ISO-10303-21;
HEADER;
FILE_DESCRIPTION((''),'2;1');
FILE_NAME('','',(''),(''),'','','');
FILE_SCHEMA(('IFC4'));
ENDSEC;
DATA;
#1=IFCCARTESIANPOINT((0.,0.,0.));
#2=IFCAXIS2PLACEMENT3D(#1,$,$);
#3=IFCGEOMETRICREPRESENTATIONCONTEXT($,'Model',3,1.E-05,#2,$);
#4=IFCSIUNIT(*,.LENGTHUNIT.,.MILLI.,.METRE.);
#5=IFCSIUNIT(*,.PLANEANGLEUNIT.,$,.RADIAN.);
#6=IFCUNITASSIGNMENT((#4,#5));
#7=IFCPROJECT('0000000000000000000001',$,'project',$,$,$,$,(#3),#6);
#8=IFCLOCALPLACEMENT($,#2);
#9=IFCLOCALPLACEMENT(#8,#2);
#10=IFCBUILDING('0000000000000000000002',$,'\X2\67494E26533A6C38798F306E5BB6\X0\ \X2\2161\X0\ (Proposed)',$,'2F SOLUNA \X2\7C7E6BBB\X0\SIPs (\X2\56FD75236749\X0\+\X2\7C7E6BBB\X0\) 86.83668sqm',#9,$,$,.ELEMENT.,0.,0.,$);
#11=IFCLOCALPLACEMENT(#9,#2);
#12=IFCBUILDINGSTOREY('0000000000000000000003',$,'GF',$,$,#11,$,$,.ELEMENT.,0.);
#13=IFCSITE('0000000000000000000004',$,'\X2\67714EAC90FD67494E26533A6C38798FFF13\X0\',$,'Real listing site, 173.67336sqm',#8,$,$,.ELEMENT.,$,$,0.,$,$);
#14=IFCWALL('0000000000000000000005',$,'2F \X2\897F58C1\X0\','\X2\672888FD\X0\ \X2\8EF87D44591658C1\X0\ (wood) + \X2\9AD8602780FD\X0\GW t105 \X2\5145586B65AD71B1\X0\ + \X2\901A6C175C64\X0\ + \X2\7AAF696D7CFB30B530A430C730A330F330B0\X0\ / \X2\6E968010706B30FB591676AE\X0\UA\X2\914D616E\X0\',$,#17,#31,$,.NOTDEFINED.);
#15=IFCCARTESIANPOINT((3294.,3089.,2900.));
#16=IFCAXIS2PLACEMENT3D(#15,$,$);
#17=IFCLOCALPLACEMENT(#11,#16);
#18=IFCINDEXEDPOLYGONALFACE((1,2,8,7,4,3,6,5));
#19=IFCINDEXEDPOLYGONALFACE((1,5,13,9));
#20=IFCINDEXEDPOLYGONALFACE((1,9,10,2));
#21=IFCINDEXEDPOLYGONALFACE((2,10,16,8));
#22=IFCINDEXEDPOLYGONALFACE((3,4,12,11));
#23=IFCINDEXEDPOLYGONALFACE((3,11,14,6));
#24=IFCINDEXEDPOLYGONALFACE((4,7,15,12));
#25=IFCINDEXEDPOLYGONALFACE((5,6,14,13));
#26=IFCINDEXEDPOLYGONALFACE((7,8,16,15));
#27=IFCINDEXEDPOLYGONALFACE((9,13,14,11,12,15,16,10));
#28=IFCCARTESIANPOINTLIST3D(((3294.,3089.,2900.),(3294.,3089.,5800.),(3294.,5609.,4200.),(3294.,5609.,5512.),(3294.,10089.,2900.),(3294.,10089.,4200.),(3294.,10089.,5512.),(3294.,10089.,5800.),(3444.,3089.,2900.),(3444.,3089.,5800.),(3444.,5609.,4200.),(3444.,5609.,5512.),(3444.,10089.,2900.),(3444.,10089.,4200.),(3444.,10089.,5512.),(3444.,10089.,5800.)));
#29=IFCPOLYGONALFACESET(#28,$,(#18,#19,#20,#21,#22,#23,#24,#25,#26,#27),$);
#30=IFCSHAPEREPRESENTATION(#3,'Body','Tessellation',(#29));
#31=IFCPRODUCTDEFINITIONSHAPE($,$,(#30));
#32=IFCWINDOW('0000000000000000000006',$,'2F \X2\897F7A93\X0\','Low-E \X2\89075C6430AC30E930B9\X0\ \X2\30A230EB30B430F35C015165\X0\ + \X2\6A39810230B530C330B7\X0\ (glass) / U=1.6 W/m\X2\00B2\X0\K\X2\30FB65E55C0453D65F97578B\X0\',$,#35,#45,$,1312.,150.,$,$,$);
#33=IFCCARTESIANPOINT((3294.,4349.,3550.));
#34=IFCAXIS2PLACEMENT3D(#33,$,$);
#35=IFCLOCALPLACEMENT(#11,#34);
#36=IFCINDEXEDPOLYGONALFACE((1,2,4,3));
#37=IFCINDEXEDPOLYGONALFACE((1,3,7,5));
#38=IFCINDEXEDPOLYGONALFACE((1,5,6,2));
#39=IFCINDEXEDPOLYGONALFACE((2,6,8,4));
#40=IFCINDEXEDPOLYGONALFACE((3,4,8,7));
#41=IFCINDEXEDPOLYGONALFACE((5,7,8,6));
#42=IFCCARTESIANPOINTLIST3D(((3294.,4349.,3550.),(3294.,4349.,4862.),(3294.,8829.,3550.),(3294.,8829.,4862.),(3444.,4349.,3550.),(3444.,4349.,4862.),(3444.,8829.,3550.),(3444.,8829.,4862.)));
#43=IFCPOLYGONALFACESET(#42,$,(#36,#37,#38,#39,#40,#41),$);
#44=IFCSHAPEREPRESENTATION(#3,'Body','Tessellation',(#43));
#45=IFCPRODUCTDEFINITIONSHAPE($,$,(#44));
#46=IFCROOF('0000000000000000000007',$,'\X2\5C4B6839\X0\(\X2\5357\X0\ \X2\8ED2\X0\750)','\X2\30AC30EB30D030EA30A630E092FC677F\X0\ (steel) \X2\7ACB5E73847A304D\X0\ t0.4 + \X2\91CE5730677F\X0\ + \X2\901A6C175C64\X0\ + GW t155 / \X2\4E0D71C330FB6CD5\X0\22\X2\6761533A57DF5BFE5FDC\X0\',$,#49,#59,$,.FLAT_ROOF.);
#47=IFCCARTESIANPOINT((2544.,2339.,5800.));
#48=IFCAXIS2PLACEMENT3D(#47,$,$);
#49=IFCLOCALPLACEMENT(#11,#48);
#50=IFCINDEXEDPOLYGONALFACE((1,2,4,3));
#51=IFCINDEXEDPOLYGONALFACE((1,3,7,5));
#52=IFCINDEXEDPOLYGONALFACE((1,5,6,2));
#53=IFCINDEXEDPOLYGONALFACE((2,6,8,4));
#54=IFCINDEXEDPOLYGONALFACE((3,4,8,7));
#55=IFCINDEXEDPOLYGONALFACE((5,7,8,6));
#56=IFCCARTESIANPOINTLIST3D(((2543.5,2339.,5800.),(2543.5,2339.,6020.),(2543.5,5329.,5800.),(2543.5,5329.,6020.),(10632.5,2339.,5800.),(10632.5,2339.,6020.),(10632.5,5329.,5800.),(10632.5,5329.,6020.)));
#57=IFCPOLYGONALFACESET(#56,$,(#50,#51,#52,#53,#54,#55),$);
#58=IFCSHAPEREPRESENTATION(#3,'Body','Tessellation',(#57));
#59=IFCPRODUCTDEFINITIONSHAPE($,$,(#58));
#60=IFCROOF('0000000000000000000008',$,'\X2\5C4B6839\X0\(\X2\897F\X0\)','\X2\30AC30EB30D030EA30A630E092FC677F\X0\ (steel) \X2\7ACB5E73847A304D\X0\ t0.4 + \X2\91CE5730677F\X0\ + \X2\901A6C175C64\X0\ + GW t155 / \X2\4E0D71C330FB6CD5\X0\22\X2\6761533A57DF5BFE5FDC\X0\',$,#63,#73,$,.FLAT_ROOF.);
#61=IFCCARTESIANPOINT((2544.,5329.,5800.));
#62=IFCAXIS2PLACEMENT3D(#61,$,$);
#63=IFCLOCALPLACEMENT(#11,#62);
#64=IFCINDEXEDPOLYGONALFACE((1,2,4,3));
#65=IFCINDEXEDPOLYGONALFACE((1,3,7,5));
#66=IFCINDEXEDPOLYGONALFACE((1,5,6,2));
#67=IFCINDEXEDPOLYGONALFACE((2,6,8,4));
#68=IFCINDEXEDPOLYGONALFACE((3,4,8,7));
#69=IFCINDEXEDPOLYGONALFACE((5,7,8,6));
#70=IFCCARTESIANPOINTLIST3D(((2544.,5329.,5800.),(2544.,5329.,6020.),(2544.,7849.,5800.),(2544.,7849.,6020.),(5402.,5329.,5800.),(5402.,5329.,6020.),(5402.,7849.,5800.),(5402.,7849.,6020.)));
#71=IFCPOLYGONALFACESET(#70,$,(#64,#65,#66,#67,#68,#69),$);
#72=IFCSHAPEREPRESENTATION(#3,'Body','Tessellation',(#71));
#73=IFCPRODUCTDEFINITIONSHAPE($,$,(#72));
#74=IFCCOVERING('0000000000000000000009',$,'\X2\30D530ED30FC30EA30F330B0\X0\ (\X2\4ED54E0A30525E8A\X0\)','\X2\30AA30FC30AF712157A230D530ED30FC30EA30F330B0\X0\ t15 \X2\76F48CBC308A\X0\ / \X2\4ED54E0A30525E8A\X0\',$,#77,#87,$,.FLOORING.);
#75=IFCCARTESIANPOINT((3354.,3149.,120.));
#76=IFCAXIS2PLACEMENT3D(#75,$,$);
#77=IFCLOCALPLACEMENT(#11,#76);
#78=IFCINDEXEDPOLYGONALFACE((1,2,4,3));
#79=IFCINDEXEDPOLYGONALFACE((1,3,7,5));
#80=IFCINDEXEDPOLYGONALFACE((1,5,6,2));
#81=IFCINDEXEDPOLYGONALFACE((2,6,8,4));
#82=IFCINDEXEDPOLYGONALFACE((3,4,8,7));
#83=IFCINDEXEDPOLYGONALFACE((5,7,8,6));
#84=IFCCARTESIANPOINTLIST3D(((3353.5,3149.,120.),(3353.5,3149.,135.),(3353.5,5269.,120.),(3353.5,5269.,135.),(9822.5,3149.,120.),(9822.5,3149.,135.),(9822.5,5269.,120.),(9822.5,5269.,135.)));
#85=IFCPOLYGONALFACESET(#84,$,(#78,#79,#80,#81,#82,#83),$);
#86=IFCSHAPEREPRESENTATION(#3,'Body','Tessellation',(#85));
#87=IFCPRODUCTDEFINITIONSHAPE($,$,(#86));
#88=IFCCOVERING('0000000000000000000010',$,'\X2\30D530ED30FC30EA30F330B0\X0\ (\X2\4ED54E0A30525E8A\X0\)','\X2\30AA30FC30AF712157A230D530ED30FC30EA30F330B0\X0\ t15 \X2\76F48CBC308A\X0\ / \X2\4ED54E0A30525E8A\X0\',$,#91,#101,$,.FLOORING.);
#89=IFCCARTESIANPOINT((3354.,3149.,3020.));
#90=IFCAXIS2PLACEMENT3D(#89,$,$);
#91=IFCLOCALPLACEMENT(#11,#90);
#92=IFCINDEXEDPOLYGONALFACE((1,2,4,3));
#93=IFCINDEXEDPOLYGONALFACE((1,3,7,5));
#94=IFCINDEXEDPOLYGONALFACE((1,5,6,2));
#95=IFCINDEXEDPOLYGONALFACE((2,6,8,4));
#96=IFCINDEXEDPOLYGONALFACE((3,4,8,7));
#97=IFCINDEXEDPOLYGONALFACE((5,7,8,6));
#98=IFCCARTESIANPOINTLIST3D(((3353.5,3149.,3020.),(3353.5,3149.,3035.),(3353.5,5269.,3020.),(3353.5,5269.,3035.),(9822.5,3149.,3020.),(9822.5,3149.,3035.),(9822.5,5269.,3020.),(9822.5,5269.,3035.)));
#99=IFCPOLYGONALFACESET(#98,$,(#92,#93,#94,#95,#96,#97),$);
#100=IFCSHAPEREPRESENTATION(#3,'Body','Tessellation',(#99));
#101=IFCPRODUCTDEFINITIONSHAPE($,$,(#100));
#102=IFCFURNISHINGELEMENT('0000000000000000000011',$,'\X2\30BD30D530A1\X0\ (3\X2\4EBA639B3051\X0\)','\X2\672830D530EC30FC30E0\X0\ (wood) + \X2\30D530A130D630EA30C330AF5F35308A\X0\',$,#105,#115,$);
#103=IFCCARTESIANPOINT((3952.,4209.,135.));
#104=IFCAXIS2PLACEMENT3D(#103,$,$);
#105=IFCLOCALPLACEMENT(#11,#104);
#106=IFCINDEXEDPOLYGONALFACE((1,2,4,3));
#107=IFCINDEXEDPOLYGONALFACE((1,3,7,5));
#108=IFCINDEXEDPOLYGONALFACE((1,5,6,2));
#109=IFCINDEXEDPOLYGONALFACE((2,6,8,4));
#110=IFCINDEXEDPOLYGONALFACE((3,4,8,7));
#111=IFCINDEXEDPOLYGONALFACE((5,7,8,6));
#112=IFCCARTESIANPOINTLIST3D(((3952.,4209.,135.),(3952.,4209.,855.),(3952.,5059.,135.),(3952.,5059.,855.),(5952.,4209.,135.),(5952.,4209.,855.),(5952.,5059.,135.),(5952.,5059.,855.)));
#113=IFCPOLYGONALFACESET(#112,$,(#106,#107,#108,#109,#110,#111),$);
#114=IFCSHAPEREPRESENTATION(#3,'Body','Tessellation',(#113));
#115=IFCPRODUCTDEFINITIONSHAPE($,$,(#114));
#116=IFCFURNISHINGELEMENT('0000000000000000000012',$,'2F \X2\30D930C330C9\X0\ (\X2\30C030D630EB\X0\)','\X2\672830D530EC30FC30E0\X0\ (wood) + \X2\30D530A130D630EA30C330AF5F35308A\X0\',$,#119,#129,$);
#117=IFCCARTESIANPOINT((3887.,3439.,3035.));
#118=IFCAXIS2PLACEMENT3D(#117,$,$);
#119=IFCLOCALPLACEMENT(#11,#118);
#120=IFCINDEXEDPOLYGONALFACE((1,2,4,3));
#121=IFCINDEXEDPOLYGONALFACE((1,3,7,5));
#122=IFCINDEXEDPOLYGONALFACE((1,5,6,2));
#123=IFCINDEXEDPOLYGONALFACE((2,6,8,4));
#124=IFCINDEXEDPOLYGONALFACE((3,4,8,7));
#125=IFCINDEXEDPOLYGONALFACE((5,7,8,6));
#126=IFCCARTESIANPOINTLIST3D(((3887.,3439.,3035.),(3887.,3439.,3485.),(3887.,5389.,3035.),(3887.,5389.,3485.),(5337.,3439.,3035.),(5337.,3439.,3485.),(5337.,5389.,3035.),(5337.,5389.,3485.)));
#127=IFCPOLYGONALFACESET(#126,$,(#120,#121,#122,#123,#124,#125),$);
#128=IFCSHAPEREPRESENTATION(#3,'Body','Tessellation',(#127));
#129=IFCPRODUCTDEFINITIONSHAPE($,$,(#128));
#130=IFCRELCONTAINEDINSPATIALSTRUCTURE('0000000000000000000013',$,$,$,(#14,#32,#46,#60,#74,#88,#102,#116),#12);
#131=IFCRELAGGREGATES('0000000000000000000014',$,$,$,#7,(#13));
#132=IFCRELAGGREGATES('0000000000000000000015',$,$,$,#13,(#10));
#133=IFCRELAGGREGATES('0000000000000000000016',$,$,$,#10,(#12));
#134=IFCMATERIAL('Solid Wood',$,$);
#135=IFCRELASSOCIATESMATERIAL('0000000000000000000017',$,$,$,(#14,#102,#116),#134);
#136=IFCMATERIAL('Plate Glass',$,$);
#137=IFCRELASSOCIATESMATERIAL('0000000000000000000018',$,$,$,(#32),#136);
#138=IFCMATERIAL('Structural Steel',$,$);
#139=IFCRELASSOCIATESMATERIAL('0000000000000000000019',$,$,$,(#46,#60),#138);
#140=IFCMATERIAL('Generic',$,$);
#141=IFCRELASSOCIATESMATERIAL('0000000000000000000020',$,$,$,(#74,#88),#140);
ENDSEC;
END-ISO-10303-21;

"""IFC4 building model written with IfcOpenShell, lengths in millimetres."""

from ifc_helpers import new_model, si_unit, frame, frame_2d, origin, place, context, project, spatial, rectangle, extrude, material, element, fill, save


model = new_model("IFC4")

# Units and contexts
model_context = context("Model", 3, precision=1e-05, world=origin())
ifc_project = project(units=[si_unit("LENGTHUNIT", "METRE", prefix="MILLI"), si_unit("PLANEANGLEUNIT", "RADIAN")], contexts=[model_context])

# Site, building, storey
site_placement = place(None, origin())
site = spatial("IfcSite", under=ifc_project, at=site_placement, Name="東京都杉並区永福３", ObjectType="Real listing site, 173.67336sqm", CompositionType="ELEMENT", RefElevation=0.0)
building_placement = place(site_placement, origin())
building = spatial("IfcBuilding", under=site, at=building_placement, Name="杉並区永福の家 Ⅱ (Proposed)", ObjectType="2F SOLUNA 籾殻SIPs (国産杉+籾殻) 86.83668sqm", CompositionType="ELEMENT", ElevationOfRefHeight=0.0, ElevationOfTerrain=0.0)
storey_placement = place(building_placement, origin())
storey = spatial("IfcBuildingStorey", under=building, at=storey_placement, Name="GF", CompositionType="ELEMENT", Elevation=0.0)

# Shared definitions
ifc_material_1 = material(Name="Solid Wood")

# Shared definitions
ifc_material_2 = material(Name="Plate Glass")

# Wall, opening, window
wall_1_placement = place(storey_placement, frame((3294.0, 3089.0, 2900.0)))
wall_1 = element("IfcWall", 1, at=wall_1_placement, inside=storey, material=ifc_material_1, Name="2F 西壁", Description="木製 軸組外壁 (wood) + 高性能GW t105 充填断熱 + 通気層 + 窯業系サイディング / 準耐火・外皮UA配慮", PredefinedType="NOTDEFINED", context=model_context, shape_type="SweptSolid", body=[
    extrude(rectangle(XDim=150.0, YDim=7000.0, at=frame_2d((75.0, 3500.0))), frame((3294.0, 3089.0, 2900.0)), (0.0, 0.0, 1.0), 2900.0),
])
opening_1_placement = place(storey_placement, frame((3294.0, 4349.0, 3550.0)))
opening_1 = element("IfcOpeningElement", 2, at=opening_1_placement, cuts=wall_1, PredefinedType="NOTDEFINED", context=model_context, shape_type="SweptSolid", body=[
    extrude(rectangle(XDim=150.0, YDim=4480.0, at=frame_2d((75.0, 2240.0))), frame((3294.0, 4349.0, 3550.0)), (0.0, 0.0, 1.0), 1312.0),
])
window_1_placement = place(storey_placement, frame((3294.0, 4349.0, 3550.0)))
window_1 = element("IfcWindow", 3, at=window_1_placement, inside=storey, material=ifc_material_2, Name="2F 西窓", Description="Low-E 複層ガラス アルゴン封入 + 樹脂サッシ (glass) / U=1.6 W/m²K・日射取得型", OverallHeight=1312.0, OverallWidth=150.0, context=model_context, shape_type="SweptSolid", body=[
    extrude(rectangle(XDim=150.0, YDim=4480.0, at=frame_2d((75.0, 2240.0))), frame((3294.0, 4349.0, 3550.0)), (0.0, 0.0, 1.0), 1312.0),
])
fill(opening_1, window_1)

# Roofs
ifc_material_3 = material(Name="Structural Steel")
roof_1_placement = place(storey_placement, frame((2544.0, 2339.0, 5800.0)))
element("IfcRoof", 4, at=roof_1_placement, inside=storey, material=ifc_material_3, Name="屋根(南 軒750)", Description="ガルバリウム鋼板 (steel) 立平葺き t0.4 + 野地板 + 通気層 + GW t155 / 不燃・法22条区域対応", PredefinedType="FLAT_ROOF", context=model_context, shape_type="SweptSolid", body=[
    extrude(rectangle(XDim=8089.0, YDim=2990.0, at=frame_2d((4044.0, 1495.0))), frame((2544.0, 2339.0, 5800.0)), (0.0, 0.0, 1.0), 220.0),
])
roof_2_placement = place(storey_placement, frame((2544.0, 5329.0, 5800.0)))
element("IfcRoof", 5, at=roof_2_placement, inside=storey, material=ifc_material_3, Name="屋根(西)", Description="ガルバリウム鋼板 (steel) 立平葺き t0.4 + 野地板 + 通気層 + GW t155 / 不燃・法22条区域対応", PredefinedType="FLAT_ROOF", context=model_context, shape_type="SweptSolid", body=[
    extrude(rectangle(XDim=2858.0, YDim=2520.0, at=frame_2d((1429.0, 1260.0))), frame((2544.0, 5329.0, 5800.0)), (0.0, 0.0, 1.0), 220.0),
])

# Coverings
ifc_material_4 = material(Name="Generic")
covering_1_placement = place(storey_placement, frame((3354.0, 3149.0, 120.0)))
element("IfcCovering", 6, at=covering_1_placement, inside=storey, material=ifc_material_4, Name="フローリング (仕上げ床)", Description="オーク無垢フローリング t15 直貼り / 仕上げ床", PredefinedType="FLOORING", context=model_context, shape_type="SweptSolid", body=[
    extrude(rectangle(XDim=6469.0, YDim=2120.0, at=frame_2d((3234.0, 1060.0))), frame((3354.0, 3149.0, 120.0)), (0.0, 0.0, 1.0), 15.0),
])
covering_2_placement = place(storey_placement, frame((3354.0, 3149.0, 3020.0)))
element("IfcCovering", 7, at=covering_2_placement, inside=storey, material=ifc_material_4, Name="フローリング (仕上げ床)", Description="オーク無垢フローリング t15 直貼り / 仕上げ床", PredefinedType="FLOORING", context=model_context, shape_type="SweptSolid", body=[
    extrude(rectangle(XDim=6469.0, YDim=2120.0, at=frame_2d((3234.0, 1060.0))), frame((3354.0, 3149.0, 3020.0)), (0.0, 0.0, 1.0), 15.0),
])

# Furnishing elements
furnishing_1_placement = place(storey_placement, frame((3952.0, 4209.0, 135.0)))
element("IfcFurnishingElement", 8, at=furnishing_1_placement, inside=storey, material=ifc_material_1, Name="ソファ (3人掛け)", Description="木フレーム (wood) + ファブリック張り", context=model_context, shape_type="SweptSolid", body=[
    extrude(rectangle(XDim=2000.0, YDim=850.0, at=frame_2d((1000.0, 425.0))), frame((3952.0, 4209.0, 135.0)), (0.0, 0.0, 1.0), 720.0),
])
furnishing_2_placement = place(storey_placement, frame((3887.0, 3439.0, 3035.0)))
element("IfcFurnishingElement", 9, at=furnishing_2_placement, inside=storey, material=ifc_material_1, Name="2F ベッド (ダブル)", Description="木フレーム (wood) + ファブリック張り", context=model_context, shape_type="SweptSolid", body=[
    extrude(rectangle(XDim=1450.0, YDim=1950.0, at=frame_2d((725.0, 975.0))), frame((3887.0, 3439.0, 3035.0)), (0.0, 0.0, 1.0), 450.0),
])

save(model, "model.ifc")
